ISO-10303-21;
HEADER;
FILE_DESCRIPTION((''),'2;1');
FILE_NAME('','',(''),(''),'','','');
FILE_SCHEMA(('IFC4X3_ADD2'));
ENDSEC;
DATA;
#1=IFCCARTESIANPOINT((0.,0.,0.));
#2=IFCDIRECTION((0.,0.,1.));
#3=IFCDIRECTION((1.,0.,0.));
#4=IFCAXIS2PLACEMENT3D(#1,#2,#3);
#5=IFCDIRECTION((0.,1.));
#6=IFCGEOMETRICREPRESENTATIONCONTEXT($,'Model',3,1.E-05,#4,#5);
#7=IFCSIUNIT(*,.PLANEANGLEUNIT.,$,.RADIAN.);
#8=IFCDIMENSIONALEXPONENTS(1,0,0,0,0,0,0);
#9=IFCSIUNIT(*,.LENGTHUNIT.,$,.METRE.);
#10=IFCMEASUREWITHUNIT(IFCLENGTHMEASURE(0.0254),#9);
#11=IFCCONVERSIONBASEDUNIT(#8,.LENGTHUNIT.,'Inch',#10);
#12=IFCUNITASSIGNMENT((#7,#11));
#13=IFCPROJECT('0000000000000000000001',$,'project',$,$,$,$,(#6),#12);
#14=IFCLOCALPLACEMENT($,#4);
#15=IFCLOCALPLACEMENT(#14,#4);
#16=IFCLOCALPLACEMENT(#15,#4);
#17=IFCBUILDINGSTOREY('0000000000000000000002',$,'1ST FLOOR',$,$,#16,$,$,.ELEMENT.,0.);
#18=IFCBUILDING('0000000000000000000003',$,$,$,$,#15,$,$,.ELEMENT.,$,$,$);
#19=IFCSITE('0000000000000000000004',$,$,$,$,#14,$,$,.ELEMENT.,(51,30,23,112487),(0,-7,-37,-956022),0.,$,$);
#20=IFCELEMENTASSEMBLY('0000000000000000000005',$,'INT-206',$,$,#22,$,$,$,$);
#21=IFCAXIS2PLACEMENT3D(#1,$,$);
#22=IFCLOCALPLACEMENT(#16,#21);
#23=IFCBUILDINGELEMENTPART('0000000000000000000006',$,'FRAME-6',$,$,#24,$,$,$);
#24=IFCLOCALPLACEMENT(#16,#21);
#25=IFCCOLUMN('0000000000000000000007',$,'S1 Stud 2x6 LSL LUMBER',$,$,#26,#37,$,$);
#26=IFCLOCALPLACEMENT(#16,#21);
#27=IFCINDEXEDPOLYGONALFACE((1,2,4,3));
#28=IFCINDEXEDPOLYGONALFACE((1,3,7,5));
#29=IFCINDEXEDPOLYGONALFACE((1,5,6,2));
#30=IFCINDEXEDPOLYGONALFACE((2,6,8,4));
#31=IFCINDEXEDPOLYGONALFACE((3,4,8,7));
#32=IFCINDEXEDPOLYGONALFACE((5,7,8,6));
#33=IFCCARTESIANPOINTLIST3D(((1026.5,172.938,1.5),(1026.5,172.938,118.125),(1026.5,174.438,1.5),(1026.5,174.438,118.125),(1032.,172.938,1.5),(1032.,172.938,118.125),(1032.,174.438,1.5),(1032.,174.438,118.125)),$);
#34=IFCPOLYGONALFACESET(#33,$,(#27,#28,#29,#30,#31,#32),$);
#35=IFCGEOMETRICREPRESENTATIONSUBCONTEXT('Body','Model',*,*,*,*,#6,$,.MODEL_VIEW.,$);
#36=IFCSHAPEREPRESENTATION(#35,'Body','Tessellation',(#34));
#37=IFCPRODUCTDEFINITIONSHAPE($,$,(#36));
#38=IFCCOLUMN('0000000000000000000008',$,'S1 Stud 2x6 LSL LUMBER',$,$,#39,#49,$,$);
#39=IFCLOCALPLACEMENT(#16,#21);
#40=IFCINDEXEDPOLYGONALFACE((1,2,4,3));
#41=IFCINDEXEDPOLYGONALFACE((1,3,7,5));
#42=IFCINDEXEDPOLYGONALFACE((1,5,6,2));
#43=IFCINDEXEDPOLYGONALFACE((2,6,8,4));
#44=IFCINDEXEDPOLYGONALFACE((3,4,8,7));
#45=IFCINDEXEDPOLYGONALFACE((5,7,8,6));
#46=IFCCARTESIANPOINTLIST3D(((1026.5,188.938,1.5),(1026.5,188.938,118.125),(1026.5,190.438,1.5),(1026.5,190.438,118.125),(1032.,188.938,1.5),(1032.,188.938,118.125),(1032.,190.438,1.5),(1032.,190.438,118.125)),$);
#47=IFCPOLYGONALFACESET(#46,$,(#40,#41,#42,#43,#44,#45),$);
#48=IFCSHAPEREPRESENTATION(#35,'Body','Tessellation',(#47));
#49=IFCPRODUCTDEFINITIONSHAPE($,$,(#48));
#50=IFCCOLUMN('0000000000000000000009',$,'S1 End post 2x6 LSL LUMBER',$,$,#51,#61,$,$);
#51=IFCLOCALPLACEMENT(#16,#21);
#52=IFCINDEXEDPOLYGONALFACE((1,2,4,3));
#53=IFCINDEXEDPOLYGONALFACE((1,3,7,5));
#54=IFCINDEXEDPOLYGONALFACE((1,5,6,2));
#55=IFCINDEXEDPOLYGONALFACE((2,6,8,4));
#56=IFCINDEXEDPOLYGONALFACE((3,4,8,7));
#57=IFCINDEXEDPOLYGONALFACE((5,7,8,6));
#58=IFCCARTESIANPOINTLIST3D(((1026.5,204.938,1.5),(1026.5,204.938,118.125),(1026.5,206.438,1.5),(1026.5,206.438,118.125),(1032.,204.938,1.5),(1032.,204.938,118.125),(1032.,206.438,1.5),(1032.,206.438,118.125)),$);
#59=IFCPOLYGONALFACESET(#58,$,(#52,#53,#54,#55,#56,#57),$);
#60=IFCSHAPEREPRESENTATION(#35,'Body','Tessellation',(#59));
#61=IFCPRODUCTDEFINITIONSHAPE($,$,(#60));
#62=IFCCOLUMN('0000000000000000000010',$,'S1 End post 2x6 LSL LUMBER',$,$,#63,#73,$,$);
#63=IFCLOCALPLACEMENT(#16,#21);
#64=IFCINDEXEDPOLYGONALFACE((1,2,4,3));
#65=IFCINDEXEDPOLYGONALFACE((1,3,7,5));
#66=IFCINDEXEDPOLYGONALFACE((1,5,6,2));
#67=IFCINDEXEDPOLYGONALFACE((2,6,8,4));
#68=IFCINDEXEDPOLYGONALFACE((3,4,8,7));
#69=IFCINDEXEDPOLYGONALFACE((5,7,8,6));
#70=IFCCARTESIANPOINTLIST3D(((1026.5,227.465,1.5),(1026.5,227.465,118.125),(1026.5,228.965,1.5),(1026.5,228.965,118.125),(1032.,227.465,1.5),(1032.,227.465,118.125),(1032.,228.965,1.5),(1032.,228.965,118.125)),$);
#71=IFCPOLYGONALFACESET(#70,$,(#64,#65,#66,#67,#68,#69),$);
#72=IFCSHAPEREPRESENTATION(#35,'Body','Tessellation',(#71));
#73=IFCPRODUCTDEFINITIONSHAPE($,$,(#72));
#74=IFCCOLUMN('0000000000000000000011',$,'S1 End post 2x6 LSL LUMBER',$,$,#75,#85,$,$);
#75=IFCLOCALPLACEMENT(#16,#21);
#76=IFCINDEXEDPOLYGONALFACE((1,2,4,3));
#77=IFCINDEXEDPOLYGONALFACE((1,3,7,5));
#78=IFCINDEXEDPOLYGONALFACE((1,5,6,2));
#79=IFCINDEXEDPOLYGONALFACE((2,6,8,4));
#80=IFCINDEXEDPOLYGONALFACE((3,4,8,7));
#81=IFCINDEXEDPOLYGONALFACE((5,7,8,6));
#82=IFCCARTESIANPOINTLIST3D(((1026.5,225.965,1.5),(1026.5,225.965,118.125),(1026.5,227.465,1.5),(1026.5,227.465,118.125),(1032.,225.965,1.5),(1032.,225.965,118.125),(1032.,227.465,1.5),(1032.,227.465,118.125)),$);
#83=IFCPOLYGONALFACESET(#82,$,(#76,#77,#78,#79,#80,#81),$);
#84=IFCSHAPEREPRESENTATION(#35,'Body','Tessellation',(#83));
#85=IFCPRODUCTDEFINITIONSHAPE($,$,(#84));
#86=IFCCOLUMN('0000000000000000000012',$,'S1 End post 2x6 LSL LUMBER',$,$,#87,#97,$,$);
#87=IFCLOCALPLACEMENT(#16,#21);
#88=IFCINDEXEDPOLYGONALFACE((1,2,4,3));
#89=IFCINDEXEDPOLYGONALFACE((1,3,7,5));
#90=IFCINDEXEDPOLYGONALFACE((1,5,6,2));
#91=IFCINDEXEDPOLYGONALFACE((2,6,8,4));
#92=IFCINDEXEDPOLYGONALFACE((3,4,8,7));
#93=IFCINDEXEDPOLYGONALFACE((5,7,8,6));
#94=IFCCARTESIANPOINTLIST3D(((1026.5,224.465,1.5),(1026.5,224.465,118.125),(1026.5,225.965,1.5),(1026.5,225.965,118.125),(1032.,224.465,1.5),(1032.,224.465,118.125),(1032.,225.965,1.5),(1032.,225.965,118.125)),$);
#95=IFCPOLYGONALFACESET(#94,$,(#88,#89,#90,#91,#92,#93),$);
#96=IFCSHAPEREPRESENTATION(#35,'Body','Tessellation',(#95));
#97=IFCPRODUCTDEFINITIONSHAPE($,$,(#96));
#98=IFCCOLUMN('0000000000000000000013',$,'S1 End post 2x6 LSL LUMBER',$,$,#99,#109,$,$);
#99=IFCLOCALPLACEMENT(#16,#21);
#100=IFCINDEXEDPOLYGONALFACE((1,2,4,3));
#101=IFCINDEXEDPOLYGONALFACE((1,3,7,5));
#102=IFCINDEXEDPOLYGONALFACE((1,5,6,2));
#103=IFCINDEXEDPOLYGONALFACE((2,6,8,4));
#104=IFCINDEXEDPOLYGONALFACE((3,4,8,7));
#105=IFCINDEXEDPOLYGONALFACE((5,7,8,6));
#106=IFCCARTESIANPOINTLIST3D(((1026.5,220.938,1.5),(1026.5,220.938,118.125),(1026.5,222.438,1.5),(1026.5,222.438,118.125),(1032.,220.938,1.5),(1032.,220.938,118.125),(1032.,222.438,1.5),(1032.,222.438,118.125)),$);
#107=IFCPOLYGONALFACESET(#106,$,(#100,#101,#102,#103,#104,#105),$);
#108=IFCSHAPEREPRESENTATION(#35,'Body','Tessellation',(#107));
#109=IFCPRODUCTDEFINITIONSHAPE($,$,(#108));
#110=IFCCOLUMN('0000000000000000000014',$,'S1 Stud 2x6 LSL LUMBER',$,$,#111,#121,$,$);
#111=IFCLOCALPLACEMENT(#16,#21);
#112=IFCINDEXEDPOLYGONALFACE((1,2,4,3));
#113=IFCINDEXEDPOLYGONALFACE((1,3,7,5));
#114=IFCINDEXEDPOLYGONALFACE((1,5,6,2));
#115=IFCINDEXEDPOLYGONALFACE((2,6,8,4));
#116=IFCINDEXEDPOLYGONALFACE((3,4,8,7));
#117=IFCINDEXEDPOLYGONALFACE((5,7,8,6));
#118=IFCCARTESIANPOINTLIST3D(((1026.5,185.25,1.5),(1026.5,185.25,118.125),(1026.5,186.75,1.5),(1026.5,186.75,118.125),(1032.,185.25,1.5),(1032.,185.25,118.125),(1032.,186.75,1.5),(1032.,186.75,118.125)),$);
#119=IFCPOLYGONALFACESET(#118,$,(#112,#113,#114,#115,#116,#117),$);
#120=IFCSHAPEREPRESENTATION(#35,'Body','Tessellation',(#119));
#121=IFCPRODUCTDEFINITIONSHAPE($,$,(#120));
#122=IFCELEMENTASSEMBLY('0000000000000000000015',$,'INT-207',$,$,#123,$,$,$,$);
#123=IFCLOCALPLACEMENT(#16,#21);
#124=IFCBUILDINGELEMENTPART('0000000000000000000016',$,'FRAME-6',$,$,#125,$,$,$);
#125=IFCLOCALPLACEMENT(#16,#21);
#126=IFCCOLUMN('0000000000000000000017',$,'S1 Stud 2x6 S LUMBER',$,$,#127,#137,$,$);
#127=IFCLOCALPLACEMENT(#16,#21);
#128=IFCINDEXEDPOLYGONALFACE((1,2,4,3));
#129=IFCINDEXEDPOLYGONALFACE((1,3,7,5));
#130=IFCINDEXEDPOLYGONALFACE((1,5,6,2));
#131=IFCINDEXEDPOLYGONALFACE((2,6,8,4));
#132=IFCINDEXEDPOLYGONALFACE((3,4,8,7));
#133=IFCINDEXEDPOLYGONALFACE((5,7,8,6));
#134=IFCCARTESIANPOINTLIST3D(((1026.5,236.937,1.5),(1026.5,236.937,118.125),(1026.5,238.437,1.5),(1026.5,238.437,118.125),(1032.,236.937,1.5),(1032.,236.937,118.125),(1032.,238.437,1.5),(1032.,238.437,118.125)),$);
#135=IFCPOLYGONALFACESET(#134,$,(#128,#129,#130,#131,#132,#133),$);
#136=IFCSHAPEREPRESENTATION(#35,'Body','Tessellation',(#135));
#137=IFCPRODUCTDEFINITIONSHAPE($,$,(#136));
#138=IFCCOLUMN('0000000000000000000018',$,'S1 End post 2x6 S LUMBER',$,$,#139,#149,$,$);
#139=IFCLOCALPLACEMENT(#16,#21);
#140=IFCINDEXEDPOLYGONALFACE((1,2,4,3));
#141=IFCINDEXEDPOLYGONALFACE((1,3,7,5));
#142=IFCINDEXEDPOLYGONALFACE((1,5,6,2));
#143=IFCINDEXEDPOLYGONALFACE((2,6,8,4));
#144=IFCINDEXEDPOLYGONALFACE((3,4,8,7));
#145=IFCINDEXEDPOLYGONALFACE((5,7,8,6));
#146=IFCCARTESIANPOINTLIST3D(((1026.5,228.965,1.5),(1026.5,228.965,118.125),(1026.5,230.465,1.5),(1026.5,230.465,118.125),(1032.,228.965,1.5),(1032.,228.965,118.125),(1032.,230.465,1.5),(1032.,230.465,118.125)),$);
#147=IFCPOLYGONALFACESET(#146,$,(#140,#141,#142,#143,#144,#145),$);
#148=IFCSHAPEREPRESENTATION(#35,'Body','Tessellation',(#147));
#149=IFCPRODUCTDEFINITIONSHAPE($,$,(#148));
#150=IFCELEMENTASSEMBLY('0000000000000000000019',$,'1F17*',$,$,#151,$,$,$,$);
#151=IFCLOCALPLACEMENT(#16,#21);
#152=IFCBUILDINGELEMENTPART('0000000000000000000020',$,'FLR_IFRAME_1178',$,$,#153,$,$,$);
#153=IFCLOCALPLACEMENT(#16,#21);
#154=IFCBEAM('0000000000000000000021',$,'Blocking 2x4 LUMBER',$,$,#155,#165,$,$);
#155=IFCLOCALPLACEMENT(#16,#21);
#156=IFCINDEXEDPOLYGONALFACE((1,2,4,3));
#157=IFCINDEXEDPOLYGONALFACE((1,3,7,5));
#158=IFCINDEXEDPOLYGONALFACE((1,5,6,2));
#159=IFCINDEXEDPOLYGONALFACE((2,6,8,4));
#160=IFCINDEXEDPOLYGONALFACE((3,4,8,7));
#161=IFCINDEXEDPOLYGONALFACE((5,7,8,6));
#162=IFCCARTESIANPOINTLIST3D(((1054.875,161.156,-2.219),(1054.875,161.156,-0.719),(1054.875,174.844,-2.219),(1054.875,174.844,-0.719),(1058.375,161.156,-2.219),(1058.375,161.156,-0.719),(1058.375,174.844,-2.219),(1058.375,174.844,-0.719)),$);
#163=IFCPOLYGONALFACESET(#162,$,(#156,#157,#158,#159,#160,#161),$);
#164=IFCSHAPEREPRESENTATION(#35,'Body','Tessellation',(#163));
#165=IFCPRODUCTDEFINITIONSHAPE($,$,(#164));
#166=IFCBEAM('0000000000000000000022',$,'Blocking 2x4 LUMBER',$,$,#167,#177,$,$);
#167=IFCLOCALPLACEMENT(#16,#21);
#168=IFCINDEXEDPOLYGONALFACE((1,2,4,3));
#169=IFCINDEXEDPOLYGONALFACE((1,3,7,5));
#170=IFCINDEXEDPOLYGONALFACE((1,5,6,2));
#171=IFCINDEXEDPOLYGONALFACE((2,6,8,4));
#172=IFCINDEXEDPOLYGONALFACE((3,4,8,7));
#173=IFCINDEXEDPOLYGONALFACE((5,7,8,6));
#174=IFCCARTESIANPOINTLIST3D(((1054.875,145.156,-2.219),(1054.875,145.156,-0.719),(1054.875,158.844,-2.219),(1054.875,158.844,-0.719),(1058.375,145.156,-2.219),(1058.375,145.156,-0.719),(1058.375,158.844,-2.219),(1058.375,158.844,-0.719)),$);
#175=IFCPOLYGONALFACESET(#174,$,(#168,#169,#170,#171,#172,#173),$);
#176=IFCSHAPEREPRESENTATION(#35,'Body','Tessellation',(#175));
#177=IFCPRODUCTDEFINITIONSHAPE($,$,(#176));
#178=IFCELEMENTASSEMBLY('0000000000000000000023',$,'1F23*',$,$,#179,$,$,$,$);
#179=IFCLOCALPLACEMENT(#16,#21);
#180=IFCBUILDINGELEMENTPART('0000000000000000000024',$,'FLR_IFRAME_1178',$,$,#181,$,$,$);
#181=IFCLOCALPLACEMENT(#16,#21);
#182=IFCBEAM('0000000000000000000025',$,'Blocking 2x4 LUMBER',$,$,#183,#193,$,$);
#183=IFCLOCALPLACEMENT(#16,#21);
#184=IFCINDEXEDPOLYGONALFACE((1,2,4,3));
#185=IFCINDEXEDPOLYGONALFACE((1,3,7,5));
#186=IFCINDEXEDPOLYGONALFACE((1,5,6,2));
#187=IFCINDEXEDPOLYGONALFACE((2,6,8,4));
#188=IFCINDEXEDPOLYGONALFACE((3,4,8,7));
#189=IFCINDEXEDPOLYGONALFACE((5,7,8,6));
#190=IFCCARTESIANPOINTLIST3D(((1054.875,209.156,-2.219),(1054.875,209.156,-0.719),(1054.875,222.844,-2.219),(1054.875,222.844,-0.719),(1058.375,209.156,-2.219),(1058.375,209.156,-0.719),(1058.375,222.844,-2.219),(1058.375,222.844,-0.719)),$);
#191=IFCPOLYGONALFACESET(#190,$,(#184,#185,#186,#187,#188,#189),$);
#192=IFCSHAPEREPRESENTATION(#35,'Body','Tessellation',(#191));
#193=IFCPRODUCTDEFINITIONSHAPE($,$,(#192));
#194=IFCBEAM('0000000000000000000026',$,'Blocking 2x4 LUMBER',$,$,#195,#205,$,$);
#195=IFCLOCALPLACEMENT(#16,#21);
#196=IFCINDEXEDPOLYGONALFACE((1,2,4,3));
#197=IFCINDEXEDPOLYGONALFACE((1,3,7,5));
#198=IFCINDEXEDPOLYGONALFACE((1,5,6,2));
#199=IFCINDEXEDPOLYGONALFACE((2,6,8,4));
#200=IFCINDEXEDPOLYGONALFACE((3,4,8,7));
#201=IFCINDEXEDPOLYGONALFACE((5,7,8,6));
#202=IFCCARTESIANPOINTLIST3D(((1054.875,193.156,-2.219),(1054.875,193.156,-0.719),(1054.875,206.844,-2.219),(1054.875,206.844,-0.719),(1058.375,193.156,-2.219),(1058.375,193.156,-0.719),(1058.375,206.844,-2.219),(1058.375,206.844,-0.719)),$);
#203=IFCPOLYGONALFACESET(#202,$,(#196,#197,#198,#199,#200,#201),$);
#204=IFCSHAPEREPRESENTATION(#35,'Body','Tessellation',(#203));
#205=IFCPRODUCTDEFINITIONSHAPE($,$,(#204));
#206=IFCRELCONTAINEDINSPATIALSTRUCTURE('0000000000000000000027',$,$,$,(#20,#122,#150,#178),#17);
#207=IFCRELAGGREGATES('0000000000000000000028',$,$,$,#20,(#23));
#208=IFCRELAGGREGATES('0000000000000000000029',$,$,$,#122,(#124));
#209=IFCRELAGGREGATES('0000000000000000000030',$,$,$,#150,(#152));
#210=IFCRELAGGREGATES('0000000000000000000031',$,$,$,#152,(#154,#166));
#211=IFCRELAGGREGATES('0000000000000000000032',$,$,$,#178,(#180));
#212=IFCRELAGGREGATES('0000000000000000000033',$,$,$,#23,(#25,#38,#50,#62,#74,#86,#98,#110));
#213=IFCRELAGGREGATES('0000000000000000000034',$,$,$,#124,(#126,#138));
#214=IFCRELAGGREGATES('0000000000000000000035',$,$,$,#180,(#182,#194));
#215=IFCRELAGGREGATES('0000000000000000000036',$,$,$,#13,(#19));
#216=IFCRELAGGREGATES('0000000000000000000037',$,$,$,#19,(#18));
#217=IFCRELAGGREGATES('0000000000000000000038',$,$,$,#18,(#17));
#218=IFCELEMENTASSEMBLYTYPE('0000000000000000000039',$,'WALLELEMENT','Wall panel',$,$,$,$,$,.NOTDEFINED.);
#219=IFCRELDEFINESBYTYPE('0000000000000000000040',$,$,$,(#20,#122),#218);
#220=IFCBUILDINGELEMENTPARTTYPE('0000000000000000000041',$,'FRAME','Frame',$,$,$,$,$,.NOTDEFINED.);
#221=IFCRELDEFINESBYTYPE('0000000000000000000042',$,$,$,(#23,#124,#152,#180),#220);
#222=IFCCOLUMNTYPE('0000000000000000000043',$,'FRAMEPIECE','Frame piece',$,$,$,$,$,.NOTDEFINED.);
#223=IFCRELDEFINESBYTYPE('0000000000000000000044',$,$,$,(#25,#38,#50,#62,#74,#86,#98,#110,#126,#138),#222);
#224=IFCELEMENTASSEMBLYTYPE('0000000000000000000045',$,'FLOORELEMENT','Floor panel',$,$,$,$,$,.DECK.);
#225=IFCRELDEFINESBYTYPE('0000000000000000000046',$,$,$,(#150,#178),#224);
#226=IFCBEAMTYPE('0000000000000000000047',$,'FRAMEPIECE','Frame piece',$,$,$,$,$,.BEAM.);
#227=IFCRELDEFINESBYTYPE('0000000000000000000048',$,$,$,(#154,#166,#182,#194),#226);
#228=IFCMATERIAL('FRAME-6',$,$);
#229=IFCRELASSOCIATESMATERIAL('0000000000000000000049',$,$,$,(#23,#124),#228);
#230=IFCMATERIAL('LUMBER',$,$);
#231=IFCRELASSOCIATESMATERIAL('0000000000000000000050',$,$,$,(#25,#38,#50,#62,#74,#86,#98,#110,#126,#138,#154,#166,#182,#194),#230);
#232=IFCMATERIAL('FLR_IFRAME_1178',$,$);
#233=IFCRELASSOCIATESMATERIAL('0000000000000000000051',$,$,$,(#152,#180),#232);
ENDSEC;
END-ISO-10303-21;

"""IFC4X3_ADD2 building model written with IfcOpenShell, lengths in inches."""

from ifc_helpers import new_model, entity, si_unit, converted_unit, direction, frame, origin_with_axes, origin_2d_with_axis, place, context, subcontext, project, spatial, rectangle, extrude, material, type_object, element, aggregate, save


model = new_model("IFC4X3_ADD2")

# Units and contexts
model_context = context("Model", 3, precision=1e-05, world=origin_with_axes(), true_north=direction((0.0, 1.0)))
body_context = subcontext(model_context, "Body", "Model", "MODEL_VIEW")
ifc_project = project(units=[si_unit("PLANEANGLEUNIT", "RADIAN"), converted_unit("LENGTHUNIT", "Inch", entity("IfcLengthMeasure", 0.0254), si_unit("LENGTHUNIT", "METRE"), dimensions=[1, 0, 0, 0, 0, 0, 0])], contexts=[model_context])

# Site, building, storey
site_placement = place(None, origin_with_axes())
site = spatial("IfcSite", under=ifc_project, at=site_placement, CompositionType="ELEMENT", RefLatitude=(51, 30, 23, 112487), RefLongitude=(0, -7, -37, -956022), RefElevation=0.0)
building_placement = place(site_placement, origin_with_axes())
building = spatial("IfcBuilding", under=site, at=building_placement, CompositionType="ELEMENT")
storey_placement = place(building_placement, origin_with_axes())
storey = spatial("IfcBuildingStorey", under=building, at=storey_placement, Name="1ST FLOOR", CompositionType="ELEMENT", Elevation=0.0)

# Element assemblies, building element parts, columns
element_assembly_type_1 = type_object("IfcElementAssemblyType", Name="WALLELEMENT", Description="Wall panel", PredefinedType="NOTDEFINED")
assembly_1_placement = place(storey_placement, origin_with_axes())
assembly_1 = element("IfcElementAssembly", 1, at=assembly_1_placement, inside=storey, type_object=element_assembly_type_1, Name="INT-206")
ifc_material_1 = material(Name="FRAME-6")
building_element_part_type = type_object("IfcBuildingElementPartType", Name="FRAME", Description="Frame", PredefinedType="NOTDEFINED")
building_element_part_1_placement = place(storey_placement, origin_with_axes())
building_element_part_1 = element("IfcBuildingElementPart", 2, at=building_element_part_1_placement, type_object=building_element_part_type, material=ifc_material_1, Name="FRAME-6")
aggregate(assembly_1, [building_element_part_1])
ifc_material_2 = material(Name="LUMBER")
column_type = type_object("IfcColumnType", Name="FRAMEPIECE", Description="Frame piece", PredefinedType="NOTDEFINED")
column_1_placement = place(storey_placement, frame((1029.25, 173.688, 118.125), z_axis=(0.0, 0.0, -1.0), x_axis=(0.0, -1.0, 0.0)))
column_1 = element("IfcColumn", 3, at=column_1_placement, type_object=column_type, material=ifc_material_2, Name="S1 Stud 2x6 LSL LUMBER", context=body_context, shape_type="SweptSolid", body=[
    extrude(rectangle(XDim=1.5, YDim=5.5, at=origin_2d_with_axis()), origin_with_axes(), (0.0, 0.0, 1.0), 116.625),
])
column_2_placement = place(storey_placement, frame((1029.25, 189.688, 118.125), z_axis=(0.0, 0.0, -1.0), x_axis=(0.0, -1.0, 0.0)))
column_2 = element("IfcColumn", 4, at=column_2_placement, type_object=column_type, material=ifc_material_2, Name="S1 Stud 2x6 LSL LUMBER", context=body_context, shape_type="SweptSolid", body=[
    extrude(rectangle(XDim=1.5, YDim=5.5, at=origin_2d_with_axis()), origin_with_axes(), (0.0, 0.0, 1.0), 116.625),
])
column_3_placement = place(storey_placement, frame((1029.25, 205.688, 118.125), z_axis=(0.0, 0.0, -1.0), x_axis=(0.0, -1.0, 0.0)))
column_3 = element("IfcColumn", 5, at=column_3_placement, type_object=column_type, material=ifc_material_2, Name="S1 End post 2x6 LSL LUMBER", context=body_context, shape_type="SweptSolid", body=[
    extrude(rectangle(XDim=1.5, YDim=5.5, at=origin_2d_with_axis()), origin_with_axes(), (0.0, 0.0, 1.0), 116.625),
])
column_4_placement = place(storey_placement, frame((1029.25, 228.215, 118.125), z_axis=(0.0, 0.0, -1.0), x_axis=(0.0, -1.0, 0.0)))
column_4 = element("IfcColumn", 6, at=column_4_placement, type_object=column_type, material=ifc_material_2, Name="S1 End post 2x6 LSL LUMBER", context=body_context, shape_type="SweptSolid", body=[
    extrude(rectangle(XDim=1.5, YDim=5.5, at=origin_2d_with_axis()), origin_with_axes(), (0.0, 0.0, 1.0), 116.625),
])
column_5_placement = place(storey_placement, frame((1029.25, 226.715, 1.5), z_axis=(0.0, 0.0, 1.0), x_axis=(0.0, 1.0, 0.0)))
column_5 = element("IfcColumn", 7, at=column_5_placement, type_object=column_type, material=ifc_material_2, Name="S1 End post 2x6 LSL LUMBER", context=body_context, shape_type="SweptSolid", body=[
    extrude(rectangle(XDim=1.5, YDim=5.5, at=origin_2d_with_axis()), origin_with_axes(), (0.0, 0.0, 1.0), 116.625),
])
column_6_placement = place(storey_placement, frame((1029.25, 225.215, 118.125), z_axis=(0.0, 0.0, -1.0), x_axis=(0.0, -1.0, 0.0)))
column_6 = element("IfcColumn", 8, at=column_6_placement, type_object=column_type, material=ifc_material_2, Name="S1 End post 2x6 LSL LUMBER", context=body_context, shape_type="SweptSolid", body=[
    extrude(rectangle(XDim=1.5, YDim=5.5, at=origin_2d_with_axis()), origin_with_axes(), (0.0, 0.0, 1.0), 116.625),
])
column_7_placement = place(storey_placement, frame((1029.25, 221.688, 118.125), z_axis=(0.0, 0.0, -1.0), x_axis=(0.0, -1.0, 0.0)))
column_7 = element("IfcColumn", 9, at=column_7_placement, type_object=column_type, material=ifc_material_2, Name="S1 End post 2x6 LSL LUMBER", context=body_context, shape_type="SweptSolid", body=[
    extrude(rectangle(XDim=1.5, YDim=5.5, at=origin_2d_with_axis()), origin_with_axes(), (0.0, 0.0, 1.0), 116.625),
])
column_8_placement = place(storey_placement, frame((1029.25, 186.0, 118.125), z_axis=(0.0, 0.0, -1.0), x_axis=(0.0, -1.0, 0.0)))
column_8 = element("IfcColumn", 10, at=column_8_placement, type_object=column_type, material=ifc_material_2, Name="S1 Stud 2x6 LSL LUMBER", context=body_context, shape_type="SweptSolid", body=[
    extrude(rectangle(XDim=1.5, YDim=5.5, at=origin_2d_with_axis()), origin_with_axes(), (0.0, 0.0, 1.0), 116.625),
])
assembly_2_placement = place(storey_placement, origin_with_axes())
assembly_2 = element("IfcElementAssembly", 11, at=assembly_2_placement, inside=storey, type_object=element_assembly_type_1, Name="INT-207")
building_element_part_2_placement = place(storey_placement, origin_with_axes())
building_element_part_2 = element("IfcBuildingElementPart", 12, at=building_element_part_2_placement, type_object=building_element_part_type, material=ifc_material_1, Name="FRAME-6")
aggregate(assembly_2, [building_element_part_2])
column_9_placement = place(storey_placement, frame((1029.25, 237.687, 118.125), z_axis=(0.0, 0.0, -1.0), x_axis=(0.0, -1.0, 0.0)))
column_9 = element("IfcColumn", 13, at=column_9_placement, type_object=column_type, material=ifc_material_2, Name="S1 Stud 2x6 S LUMBER", context=body_context, shape_type="SweptSolid", body=[
    extrude(rectangle(XDim=1.5, YDim=5.5, at=origin_2d_with_axis()), origin_with_axes(), (0.0, 0.0, 1.0), 116.625),
])
column_10_placement = place(storey_placement, frame((1029.25, 229.715, 1.5), z_axis=(0.0, 0.0, 1.0), x_axis=(0.0, 1.0, 0.0)))
column_10 = element("IfcColumn", 14, at=column_10_placement, type_object=column_type, material=ifc_material_2, Name="S1 End post 2x6 S LUMBER", context=body_context, shape_type="SweptSolid", body=[
    extrude(rectangle(XDim=1.5, YDim=5.5, at=origin_2d_with_axis()), origin_with_axes(), (0.0, 0.0, 1.0), 116.625),
])

# Element assemblies, building element parts, beams
element_assembly_type_2 = type_object("IfcElementAssemblyType", Name="FLOORELEMENT", Description="Floor panel", PredefinedType="DECK")
assembly_3_placement = place(storey_placement, origin_with_axes())
assembly_3 = element("IfcElementAssembly", 15, at=assembly_3_placement, inside=storey, type_object=element_assembly_type_2, Name="1F17*")
ifc_material_3 = material(Name="FLR_IFRAME_1178")
building_element_part_3_placement = place(storey_placement, origin_with_axes())
building_element_part_3 = element("IfcBuildingElementPart", 16, at=building_element_part_3_placement, type_object=building_element_part_type, material=ifc_material_3, Name="FLR_IFRAME_1178")
aggregate(assembly_3, [building_element_part_3])
beam_type_1 = type_object("IfcBeamType", Name="FRAMEPIECE", Description="Frame piece", PredefinedType="BEAM")
beam_1_placement = place(storey_placement, frame((1056.625, 174.844, -1.469), z_axis=(0.0, -1.0, 0.0), x_axis=(0.0, 0.0, 1.0)))
beam_1 = element("IfcBeam", 17, at=beam_1_placement, type_object=beam_type_1, material=ifc_material_2, Name="Blocking 2x4 LUMBER", context=body_context, shape_type="SweptSolid", body=[
    extrude(rectangle(XDim=1.5, YDim=3.5, at=origin_2d_with_axis()), origin_with_axes(), (0.0, 0.0, 1.0), 13.687),
])
beam_2_placement = place(storey_placement, frame((1056.625, 158.844, -1.469), z_axis=(0.0, -1.0, 0.0), x_axis=(0.0, 0.0, 1.0)))
beam_2 = element("IfcBeam", 18, at=beam_2_placement, type_object=beam_type_1, material=ifc_material_2, Name="Blocking 2x4 LUMBER", context=body_context, shape_type="SweptSolid", body=[
    extrude(rectangle(XDim=1.5, YDim=3.5, at=origin_2d_with_axis()), origin_with_axes(), (0.0, 0.0, 1.0), 13.687),
])
aggregate(building_element_part_3, [beam_1, beam_2])
assembly_4_placement = place(storey_placement, origin_with_axes())
assembly_4 = element("IfcElementAssembly", 19, at=assembly_4_placement, inside=storey, type_object=element_assembly_type_2, Name="1F23*")
building_element_part_4_placement = place(storey_placement, origin_with_axes())
building_element_part_4 = element("IfcBuildingElementPart", 20, at=building_element_part_4_placement, type_object=building_element_part_type, material=ifc_material_3, Name="FLR_IFRAME_1178")
aggregate(assembly_4, [building_element_part_4])
beam_3_placement = place(storey_placement, frame((1056.625, 222.844, -1.469), z_axis=(0.0, -1.0, 0.0), x_axis=(0.0, 0.0, 1.0)))
beam_3 = element("IfcBeam", 21, at=beam_3_placement, type_object=beam_type_1, material=ifc_material_2, Name="Blocking 2x4 LUMBER", context=body_context, shape_type="SweptSolid", body=[
    extrude(rectangle(XDim=1.5, YDim=3.5, at=origin_2d_with_axis()), origin_with_axes(), (0.0, 0.0, 1.0), 13.687),
])
beam_4_placement = place(storey_placement, frame((1056.625, 206.844, -1.469), z_axis=(0.0, -1.0, 0.0), x_axis=(0.0, 0.0, 1.0)))
beam_4 = element("IfcBeam", 22, at=beam_4_placement, type_object=beam_type_1, material=ifc_material_2, Name="Blocking 2x4 LUMBER", context=body_context, shape_type="SweptSolid", body=[
    extrude(rectangle(XDim=1.5, YDim=3.5, at=origin_2d_with_axis()), origin_with_axes(), (0.0, 0.0, 1.0), 13.687),
])

aggregate(building_element_part_1, [column_1, column_2, column_3, column_4, column_5, column_6, column_7, column_8])

aggregate(building_element_part_2, [column_9, column_10])
aggregate(building_element_part_4, [beam_3, beam_4])

save(model, "model.ifc")
